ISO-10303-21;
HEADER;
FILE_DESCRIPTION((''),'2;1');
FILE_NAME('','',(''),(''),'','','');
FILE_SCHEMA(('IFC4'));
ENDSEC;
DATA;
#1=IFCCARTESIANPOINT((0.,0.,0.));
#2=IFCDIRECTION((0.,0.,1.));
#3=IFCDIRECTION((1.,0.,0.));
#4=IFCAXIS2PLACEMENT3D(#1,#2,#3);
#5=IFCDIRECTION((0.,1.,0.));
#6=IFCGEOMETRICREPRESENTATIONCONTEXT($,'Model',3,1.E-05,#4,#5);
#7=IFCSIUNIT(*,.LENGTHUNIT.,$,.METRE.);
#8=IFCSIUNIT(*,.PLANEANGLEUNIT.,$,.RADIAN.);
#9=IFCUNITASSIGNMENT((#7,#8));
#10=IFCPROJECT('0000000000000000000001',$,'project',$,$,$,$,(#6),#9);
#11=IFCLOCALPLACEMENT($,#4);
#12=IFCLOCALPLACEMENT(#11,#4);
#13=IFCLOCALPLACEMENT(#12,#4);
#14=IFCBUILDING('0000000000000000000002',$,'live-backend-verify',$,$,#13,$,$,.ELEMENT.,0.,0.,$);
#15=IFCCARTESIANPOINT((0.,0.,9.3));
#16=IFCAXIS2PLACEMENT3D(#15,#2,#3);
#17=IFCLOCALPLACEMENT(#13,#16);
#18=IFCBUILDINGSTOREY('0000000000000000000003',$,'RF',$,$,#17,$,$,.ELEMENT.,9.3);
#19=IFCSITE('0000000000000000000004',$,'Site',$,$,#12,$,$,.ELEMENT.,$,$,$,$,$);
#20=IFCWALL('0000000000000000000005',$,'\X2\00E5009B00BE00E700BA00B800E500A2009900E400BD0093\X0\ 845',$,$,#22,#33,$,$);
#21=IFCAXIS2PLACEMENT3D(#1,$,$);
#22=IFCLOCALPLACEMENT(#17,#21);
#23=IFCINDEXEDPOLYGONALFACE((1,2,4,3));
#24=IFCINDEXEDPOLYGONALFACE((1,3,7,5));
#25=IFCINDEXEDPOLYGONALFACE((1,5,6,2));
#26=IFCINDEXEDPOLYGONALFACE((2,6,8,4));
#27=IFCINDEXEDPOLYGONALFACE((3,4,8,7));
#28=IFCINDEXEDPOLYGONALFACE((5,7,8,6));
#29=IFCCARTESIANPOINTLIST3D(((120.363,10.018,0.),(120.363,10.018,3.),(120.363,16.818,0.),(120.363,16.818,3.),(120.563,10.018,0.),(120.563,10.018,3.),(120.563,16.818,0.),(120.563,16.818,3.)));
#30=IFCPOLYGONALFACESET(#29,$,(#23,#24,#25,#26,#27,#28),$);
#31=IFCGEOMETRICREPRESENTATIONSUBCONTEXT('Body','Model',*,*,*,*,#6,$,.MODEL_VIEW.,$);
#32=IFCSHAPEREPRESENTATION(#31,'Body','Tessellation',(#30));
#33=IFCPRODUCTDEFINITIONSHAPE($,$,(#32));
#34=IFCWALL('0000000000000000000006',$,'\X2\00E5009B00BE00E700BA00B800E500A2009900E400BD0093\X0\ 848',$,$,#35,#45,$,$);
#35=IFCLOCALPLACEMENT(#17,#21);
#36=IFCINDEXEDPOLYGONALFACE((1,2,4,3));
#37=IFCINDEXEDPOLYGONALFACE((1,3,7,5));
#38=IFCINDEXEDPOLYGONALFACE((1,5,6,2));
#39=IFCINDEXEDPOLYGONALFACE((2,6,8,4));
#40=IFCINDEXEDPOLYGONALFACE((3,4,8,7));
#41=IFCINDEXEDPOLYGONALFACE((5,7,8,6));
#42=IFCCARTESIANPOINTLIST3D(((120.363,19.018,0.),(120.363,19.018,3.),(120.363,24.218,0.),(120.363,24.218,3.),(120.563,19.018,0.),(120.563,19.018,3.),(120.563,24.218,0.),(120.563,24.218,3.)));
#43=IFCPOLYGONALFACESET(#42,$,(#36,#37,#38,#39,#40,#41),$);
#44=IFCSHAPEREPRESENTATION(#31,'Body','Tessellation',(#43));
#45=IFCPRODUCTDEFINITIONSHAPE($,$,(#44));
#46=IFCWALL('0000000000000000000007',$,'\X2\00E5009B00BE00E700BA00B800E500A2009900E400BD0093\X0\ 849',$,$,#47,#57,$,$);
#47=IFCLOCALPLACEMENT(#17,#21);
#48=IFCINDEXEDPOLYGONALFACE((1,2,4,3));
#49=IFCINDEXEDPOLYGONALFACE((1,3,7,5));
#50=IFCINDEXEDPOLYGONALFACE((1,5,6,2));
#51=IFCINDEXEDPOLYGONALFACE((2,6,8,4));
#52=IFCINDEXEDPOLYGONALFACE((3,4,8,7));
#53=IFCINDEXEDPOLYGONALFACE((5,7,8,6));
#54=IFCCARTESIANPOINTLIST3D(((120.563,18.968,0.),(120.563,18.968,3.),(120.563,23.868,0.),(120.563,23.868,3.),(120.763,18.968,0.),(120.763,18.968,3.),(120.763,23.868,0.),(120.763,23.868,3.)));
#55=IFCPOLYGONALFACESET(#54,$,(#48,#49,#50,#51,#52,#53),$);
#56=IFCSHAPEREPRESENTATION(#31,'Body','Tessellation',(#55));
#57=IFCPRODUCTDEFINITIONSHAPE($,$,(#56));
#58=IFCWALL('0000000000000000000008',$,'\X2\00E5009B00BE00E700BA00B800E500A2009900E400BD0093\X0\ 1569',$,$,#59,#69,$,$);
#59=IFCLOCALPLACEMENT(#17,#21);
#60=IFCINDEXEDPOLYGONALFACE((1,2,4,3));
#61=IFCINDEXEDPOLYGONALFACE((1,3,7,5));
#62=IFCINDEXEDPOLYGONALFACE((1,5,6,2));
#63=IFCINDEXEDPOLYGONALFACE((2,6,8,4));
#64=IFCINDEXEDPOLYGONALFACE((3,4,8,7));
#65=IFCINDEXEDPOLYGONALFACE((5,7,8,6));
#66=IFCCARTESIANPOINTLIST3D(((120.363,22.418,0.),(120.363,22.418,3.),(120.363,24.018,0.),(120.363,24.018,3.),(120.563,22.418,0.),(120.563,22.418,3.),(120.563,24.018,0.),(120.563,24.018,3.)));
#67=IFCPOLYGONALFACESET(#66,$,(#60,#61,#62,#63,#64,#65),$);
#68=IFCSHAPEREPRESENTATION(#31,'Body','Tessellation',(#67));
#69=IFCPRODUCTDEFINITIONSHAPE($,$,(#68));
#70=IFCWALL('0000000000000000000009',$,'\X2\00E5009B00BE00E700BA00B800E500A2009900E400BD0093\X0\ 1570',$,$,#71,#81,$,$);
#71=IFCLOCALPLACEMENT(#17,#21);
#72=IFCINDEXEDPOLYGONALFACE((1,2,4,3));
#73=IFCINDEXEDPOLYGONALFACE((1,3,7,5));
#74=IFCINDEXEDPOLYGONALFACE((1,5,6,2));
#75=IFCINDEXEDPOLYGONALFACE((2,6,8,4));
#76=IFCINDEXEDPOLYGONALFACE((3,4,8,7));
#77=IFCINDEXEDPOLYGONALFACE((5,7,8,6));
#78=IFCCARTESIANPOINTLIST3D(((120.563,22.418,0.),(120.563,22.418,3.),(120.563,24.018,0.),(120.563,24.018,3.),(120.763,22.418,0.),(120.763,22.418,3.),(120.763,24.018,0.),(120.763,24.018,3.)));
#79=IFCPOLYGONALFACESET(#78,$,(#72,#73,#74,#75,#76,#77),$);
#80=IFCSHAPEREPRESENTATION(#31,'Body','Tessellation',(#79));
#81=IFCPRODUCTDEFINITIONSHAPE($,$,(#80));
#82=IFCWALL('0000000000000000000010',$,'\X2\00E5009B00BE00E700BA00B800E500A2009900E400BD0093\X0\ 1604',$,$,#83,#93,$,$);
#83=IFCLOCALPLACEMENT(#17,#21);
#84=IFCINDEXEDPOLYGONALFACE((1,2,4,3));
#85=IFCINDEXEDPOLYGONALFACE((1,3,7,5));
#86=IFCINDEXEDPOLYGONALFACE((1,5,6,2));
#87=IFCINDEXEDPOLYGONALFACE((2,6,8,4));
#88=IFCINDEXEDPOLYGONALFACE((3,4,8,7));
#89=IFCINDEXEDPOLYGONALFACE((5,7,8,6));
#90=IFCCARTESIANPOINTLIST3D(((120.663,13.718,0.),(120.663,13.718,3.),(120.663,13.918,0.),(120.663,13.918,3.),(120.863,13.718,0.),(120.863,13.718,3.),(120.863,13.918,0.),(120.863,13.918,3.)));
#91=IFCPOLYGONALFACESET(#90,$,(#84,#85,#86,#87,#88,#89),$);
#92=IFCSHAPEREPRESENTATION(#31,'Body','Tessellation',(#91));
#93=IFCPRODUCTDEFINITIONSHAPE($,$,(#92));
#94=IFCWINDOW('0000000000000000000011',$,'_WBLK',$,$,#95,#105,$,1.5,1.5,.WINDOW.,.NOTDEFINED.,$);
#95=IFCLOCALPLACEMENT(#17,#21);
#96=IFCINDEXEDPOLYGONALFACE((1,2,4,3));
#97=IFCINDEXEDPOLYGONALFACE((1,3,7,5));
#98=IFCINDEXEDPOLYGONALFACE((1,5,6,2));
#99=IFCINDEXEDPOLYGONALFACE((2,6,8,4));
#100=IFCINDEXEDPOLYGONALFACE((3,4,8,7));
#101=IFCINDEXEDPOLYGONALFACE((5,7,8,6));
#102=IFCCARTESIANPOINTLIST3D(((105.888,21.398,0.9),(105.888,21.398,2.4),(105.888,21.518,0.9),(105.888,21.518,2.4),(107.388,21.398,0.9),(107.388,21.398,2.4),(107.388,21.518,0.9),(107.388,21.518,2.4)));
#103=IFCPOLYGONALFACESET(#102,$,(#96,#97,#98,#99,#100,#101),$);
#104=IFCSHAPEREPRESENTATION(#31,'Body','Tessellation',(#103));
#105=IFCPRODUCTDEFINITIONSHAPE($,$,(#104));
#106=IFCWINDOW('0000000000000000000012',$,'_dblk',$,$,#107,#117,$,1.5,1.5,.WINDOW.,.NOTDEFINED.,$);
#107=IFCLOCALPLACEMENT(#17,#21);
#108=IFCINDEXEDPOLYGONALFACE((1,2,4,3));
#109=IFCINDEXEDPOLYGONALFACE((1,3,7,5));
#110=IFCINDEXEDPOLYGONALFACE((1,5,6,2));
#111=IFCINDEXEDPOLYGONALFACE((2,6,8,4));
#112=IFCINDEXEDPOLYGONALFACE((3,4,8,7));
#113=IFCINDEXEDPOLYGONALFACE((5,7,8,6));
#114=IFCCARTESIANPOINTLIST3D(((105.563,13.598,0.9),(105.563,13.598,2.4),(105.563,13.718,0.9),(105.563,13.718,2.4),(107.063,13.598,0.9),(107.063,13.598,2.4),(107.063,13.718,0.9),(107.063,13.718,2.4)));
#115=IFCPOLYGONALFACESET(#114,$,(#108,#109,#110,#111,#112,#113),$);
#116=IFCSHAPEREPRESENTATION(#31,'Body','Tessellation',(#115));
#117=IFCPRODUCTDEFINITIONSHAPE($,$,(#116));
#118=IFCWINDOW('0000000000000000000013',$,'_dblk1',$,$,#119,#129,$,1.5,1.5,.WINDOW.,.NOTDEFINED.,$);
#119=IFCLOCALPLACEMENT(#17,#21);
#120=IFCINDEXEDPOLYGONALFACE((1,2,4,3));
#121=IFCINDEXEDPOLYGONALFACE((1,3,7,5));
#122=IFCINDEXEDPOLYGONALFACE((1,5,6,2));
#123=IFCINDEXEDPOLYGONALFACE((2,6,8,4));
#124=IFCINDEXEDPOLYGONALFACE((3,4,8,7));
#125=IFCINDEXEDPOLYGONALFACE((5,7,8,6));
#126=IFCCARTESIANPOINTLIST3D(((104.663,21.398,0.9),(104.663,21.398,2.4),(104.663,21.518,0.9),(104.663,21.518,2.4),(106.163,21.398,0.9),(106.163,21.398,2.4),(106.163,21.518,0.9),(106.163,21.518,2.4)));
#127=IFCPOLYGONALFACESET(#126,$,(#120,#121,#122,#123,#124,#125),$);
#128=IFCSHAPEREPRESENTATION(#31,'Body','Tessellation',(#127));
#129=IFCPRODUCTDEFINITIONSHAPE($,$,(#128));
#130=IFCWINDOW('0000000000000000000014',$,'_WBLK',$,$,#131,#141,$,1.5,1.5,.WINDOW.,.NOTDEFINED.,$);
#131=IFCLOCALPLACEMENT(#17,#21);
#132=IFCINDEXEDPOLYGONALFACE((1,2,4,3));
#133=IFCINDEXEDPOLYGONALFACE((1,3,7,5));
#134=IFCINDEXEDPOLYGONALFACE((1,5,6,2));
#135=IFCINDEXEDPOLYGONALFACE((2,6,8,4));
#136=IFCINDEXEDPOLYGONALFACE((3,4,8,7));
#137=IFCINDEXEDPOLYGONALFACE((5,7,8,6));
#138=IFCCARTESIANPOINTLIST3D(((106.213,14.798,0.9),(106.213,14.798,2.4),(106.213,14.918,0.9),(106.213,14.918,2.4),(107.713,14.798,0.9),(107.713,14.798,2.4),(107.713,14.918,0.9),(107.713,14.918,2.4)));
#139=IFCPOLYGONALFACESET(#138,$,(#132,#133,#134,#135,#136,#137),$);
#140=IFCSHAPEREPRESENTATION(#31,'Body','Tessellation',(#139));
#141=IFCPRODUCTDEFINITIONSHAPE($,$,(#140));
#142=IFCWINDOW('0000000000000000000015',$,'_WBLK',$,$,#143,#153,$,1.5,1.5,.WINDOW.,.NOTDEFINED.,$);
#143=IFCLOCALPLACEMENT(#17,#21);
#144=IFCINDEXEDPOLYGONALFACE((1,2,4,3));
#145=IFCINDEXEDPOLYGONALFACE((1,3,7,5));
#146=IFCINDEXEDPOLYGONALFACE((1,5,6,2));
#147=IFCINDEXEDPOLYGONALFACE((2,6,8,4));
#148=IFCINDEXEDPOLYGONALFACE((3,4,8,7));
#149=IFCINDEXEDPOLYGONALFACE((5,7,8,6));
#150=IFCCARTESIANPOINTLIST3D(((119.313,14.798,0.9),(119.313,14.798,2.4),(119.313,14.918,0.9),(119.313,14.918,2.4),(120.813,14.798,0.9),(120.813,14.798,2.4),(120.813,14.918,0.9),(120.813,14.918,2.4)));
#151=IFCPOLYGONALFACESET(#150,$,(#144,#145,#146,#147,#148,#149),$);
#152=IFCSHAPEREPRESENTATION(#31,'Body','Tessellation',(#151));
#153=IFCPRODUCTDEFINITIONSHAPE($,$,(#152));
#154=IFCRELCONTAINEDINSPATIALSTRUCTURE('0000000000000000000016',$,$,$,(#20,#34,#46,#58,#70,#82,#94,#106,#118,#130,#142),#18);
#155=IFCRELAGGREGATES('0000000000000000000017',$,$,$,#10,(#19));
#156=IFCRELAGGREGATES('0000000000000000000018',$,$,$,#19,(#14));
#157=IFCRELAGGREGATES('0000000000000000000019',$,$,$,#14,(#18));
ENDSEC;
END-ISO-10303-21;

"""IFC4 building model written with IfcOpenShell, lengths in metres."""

from ifc_helpers import new_model, si_unit, direction, frame, frame_2d, origin_with_axes, place, context, subcontext, project, spatial, rectangle, extrude, element, save


model = new_model("IFC4")

# Units and contexts
model_context = context("Model", 3, precision=1e-05, world=origin_with_axes(), true_north=direction((0.0, 1.0, 0.0)))
body_context = subcontext(model_context, "Body", "Model", "MODEL_VIEW")
ifc_project = project(units=[si_unit("LENGTHUNIT", "METRE"), si_unit("PLANEANGLEUNIT", "RADIAN")], contexts=[model_context])

# Site, building, storey
placement = place(None, origin_with_axes())
site_placement = place(placement, origin_with_axes())
site = spatial("IfcSite", under=ifc_project, at=site_placement, Name="Site", CompositionType="ELEMENT")
building_placement = place(site_placement, origin_with_axes())
building = spatial("IfcBuilding", under=site, at=building_placement, Name="live-backend-verify", CompositionType="ELEMENT", ElevationOfRefHeight=0.0, ElevationOfTerrain=0.0)
storey_placement = place(building_placement, frame((0.0, 0.0, 9.3), z_axis=(0.0, 0.0, 1.0), x_axis=(1.0, 0.0, 0.0)))
storey = spatial("IfcBuildingStorey", under=building, at=storey_placement, Name="RF", CompositionType="ELEMENT", Elevation=9.3)

# Walls
wall_1_placement = place(storey_placement, frame((120.463, 13.418, 0.0), z_axis=(0.0, 0.0, 1.0), x_axis=(0.0, -1.0, 0.0)))
element("IfcWall", 1, at=wall_1_placement, inside=storey, Name="å\u009b¾çº¸å¢\u0099ä½\u0093 845", context=body_context, shape_type="SweptSolid", body=[
    extrude(rectangle(XDim=6.8, YDim=0.2, at=frame_2d((0.0, 0.0), x_axis=(1.0, 0.0, 0.0))), frame((0.0, 0.0, 0.0), z_axis=(0.0, 0.0, 1.0)), (0.0, 0.0, 1.0), 3.0),
])
wall_2_placement = place(storey_placement, frame((120.463, 21.618, 0.0), z_axis=(0.0, 0.0, 1.0), x_axis=(0.0, -1.0, 0.0)))
element("IfcWall", 2, at=wall_2_placement, inside=storey, Name="å\u009b¾çº¸å¢\u0099ä½\u0093 848", context=body_context, shape_type="SweptSolid", body=[
    extrude(rectangle(XDim=5.2, YDim=0.2, at=frame_2d((0.0, 0.0), x_axis=(1.0, 0.0, 0.0))), frame((0.0, 0.0, 0.0), z_axis=(0.0, 0.0, 1.0)), (0.0, 0.0, 1.0), 3.0),
])
wall_3_placement = place(storey_placement, frame((120.663, 21.418, 0.0), z_axis=(0.0, 0.0, 1.0), x_axis=(0.0, -1.0, 0.0)))
element("IfcWall", 3, at=wall_3_placement, inside=storey, Name="å\u009b¾çº¸å¢\u0099ä½\u0093 849", context=body_context, shape_type="SweptSolid", body=[
    extrude(rectangle(XDim=4.9, YDim=0.2, at=frame_2d((0.0, 0.0), x_axis=(1.0, 0.0, 0.0))), frame((0.0, 0.0, 0.0), z_axis=(0.0, 0.0, 1.0)), (0.0, 0.0, 1.0), 3.0),
])
for number, where, z_axis, x_axis, name in (
    (4, (120.463, 23.218, 0.0), (0.0, 0.0, 1.0), (0.0, -1.0, 0.0), "å\u009b¾çº¸å¢\u0099ä½\u0093 1569"),
    (5, (120.663, 23.218, 0.0), (0.0, 0.0, 1.0), (0.0, -1.0, 0.0), "å\u009b¾çº¸å¢\u0099ä½\u0093 1570"),
):
    element("IfcWall", number, at=place(storey_placement, frame(where, z_axis=z_axis, x_axis=x_axis)), inside=storey, Name=name, context=body_context, shape_type="SweptSolid", body=[
        extrude(rectangle(XDim=1.6, YDim=0.2, at=frame_2d((0.0, 0.0), x_axis=(1.0, 0.0, 0.0))), frame((0.0, 0.0, 0.0), z_axis=(0.0, 0.0, 1.0)), (0.0, 0.0, 1.0), 3.0),
    ])
wall_4_placement = place(storey_placement, frame((120.763, 13.818, 0.0), z_axis=(0.0, 0.0, 1.0), x_axis=(1.0, 0.0, 0.0)))
element("IfcWall", 6, at=wall_4_placement, inside=storey, Name="å\u009b¾çº¸å¢\u0099ä½\u0093 1604", context=body_context, shape_type="SweptSolid", body=[
    extrude(rectangle(XDim=0.2, YDim=0.2, at=frame_2d((0.0, 0.0), x_axis=(1.0, 0.0, 0.0))), frame((0.0, 0.0, 0.0), z_axis=(0.0, 0.0, 1.0)), (0.0, 0.0, 1.0), 3.0),
])

# Windows
for number, where, z_axis, x_axis, name in (
    (7, (106.638, 21.458, 0.9), (0.0, 0.0, 1.0), (1.0, 0.0, 0.0), "_WBLK"),
    (8, (106.313, 13.658, 0.9), (0.0, 0.0, 1.0), (1.0, 0.0, 0.0), "_dblk"),
    (9, (105.413, 21.458, 0.9), (0.0, 0.0, 1.0), (1.0, 0.0, 0.0), "_dblk1"),
    (10, (106.963, 14.858, 0.9), (0.0, 0.0, 1.0), (1.0, 0.0, 0.0), "_WBLK"),
    (11, (120.063, 14.858, 0.9), (0.0, 0.0, 1.0), (1.0, 0.0, 0.0), "_WBLK"),
):
    element("IfcWindow", number, at=place(storey_placement, frame(where, z_axis=z_axis, x_axis=x_axis)), inside=storey, Name=name, OverallHeight=1.5, OverallWidth=1.5, PartitioningType="NOTDEFINED", PredefinedType="WINDOW", context=body_context, shape_type="SweptSolid", body=[
        extrude(rectangle(XDim=1.5, YDim=0.12, at=frame_2d((0.0, 0.0), x_axis=(1.0, 0.0, 0.0))), frame((0.0, 0.0, 0.0), z_axis=(0.0, 0.0, 1.0)), (0.0, 0.0, 1.0), 1.5),
    ])

save(model, "model.ifc")
